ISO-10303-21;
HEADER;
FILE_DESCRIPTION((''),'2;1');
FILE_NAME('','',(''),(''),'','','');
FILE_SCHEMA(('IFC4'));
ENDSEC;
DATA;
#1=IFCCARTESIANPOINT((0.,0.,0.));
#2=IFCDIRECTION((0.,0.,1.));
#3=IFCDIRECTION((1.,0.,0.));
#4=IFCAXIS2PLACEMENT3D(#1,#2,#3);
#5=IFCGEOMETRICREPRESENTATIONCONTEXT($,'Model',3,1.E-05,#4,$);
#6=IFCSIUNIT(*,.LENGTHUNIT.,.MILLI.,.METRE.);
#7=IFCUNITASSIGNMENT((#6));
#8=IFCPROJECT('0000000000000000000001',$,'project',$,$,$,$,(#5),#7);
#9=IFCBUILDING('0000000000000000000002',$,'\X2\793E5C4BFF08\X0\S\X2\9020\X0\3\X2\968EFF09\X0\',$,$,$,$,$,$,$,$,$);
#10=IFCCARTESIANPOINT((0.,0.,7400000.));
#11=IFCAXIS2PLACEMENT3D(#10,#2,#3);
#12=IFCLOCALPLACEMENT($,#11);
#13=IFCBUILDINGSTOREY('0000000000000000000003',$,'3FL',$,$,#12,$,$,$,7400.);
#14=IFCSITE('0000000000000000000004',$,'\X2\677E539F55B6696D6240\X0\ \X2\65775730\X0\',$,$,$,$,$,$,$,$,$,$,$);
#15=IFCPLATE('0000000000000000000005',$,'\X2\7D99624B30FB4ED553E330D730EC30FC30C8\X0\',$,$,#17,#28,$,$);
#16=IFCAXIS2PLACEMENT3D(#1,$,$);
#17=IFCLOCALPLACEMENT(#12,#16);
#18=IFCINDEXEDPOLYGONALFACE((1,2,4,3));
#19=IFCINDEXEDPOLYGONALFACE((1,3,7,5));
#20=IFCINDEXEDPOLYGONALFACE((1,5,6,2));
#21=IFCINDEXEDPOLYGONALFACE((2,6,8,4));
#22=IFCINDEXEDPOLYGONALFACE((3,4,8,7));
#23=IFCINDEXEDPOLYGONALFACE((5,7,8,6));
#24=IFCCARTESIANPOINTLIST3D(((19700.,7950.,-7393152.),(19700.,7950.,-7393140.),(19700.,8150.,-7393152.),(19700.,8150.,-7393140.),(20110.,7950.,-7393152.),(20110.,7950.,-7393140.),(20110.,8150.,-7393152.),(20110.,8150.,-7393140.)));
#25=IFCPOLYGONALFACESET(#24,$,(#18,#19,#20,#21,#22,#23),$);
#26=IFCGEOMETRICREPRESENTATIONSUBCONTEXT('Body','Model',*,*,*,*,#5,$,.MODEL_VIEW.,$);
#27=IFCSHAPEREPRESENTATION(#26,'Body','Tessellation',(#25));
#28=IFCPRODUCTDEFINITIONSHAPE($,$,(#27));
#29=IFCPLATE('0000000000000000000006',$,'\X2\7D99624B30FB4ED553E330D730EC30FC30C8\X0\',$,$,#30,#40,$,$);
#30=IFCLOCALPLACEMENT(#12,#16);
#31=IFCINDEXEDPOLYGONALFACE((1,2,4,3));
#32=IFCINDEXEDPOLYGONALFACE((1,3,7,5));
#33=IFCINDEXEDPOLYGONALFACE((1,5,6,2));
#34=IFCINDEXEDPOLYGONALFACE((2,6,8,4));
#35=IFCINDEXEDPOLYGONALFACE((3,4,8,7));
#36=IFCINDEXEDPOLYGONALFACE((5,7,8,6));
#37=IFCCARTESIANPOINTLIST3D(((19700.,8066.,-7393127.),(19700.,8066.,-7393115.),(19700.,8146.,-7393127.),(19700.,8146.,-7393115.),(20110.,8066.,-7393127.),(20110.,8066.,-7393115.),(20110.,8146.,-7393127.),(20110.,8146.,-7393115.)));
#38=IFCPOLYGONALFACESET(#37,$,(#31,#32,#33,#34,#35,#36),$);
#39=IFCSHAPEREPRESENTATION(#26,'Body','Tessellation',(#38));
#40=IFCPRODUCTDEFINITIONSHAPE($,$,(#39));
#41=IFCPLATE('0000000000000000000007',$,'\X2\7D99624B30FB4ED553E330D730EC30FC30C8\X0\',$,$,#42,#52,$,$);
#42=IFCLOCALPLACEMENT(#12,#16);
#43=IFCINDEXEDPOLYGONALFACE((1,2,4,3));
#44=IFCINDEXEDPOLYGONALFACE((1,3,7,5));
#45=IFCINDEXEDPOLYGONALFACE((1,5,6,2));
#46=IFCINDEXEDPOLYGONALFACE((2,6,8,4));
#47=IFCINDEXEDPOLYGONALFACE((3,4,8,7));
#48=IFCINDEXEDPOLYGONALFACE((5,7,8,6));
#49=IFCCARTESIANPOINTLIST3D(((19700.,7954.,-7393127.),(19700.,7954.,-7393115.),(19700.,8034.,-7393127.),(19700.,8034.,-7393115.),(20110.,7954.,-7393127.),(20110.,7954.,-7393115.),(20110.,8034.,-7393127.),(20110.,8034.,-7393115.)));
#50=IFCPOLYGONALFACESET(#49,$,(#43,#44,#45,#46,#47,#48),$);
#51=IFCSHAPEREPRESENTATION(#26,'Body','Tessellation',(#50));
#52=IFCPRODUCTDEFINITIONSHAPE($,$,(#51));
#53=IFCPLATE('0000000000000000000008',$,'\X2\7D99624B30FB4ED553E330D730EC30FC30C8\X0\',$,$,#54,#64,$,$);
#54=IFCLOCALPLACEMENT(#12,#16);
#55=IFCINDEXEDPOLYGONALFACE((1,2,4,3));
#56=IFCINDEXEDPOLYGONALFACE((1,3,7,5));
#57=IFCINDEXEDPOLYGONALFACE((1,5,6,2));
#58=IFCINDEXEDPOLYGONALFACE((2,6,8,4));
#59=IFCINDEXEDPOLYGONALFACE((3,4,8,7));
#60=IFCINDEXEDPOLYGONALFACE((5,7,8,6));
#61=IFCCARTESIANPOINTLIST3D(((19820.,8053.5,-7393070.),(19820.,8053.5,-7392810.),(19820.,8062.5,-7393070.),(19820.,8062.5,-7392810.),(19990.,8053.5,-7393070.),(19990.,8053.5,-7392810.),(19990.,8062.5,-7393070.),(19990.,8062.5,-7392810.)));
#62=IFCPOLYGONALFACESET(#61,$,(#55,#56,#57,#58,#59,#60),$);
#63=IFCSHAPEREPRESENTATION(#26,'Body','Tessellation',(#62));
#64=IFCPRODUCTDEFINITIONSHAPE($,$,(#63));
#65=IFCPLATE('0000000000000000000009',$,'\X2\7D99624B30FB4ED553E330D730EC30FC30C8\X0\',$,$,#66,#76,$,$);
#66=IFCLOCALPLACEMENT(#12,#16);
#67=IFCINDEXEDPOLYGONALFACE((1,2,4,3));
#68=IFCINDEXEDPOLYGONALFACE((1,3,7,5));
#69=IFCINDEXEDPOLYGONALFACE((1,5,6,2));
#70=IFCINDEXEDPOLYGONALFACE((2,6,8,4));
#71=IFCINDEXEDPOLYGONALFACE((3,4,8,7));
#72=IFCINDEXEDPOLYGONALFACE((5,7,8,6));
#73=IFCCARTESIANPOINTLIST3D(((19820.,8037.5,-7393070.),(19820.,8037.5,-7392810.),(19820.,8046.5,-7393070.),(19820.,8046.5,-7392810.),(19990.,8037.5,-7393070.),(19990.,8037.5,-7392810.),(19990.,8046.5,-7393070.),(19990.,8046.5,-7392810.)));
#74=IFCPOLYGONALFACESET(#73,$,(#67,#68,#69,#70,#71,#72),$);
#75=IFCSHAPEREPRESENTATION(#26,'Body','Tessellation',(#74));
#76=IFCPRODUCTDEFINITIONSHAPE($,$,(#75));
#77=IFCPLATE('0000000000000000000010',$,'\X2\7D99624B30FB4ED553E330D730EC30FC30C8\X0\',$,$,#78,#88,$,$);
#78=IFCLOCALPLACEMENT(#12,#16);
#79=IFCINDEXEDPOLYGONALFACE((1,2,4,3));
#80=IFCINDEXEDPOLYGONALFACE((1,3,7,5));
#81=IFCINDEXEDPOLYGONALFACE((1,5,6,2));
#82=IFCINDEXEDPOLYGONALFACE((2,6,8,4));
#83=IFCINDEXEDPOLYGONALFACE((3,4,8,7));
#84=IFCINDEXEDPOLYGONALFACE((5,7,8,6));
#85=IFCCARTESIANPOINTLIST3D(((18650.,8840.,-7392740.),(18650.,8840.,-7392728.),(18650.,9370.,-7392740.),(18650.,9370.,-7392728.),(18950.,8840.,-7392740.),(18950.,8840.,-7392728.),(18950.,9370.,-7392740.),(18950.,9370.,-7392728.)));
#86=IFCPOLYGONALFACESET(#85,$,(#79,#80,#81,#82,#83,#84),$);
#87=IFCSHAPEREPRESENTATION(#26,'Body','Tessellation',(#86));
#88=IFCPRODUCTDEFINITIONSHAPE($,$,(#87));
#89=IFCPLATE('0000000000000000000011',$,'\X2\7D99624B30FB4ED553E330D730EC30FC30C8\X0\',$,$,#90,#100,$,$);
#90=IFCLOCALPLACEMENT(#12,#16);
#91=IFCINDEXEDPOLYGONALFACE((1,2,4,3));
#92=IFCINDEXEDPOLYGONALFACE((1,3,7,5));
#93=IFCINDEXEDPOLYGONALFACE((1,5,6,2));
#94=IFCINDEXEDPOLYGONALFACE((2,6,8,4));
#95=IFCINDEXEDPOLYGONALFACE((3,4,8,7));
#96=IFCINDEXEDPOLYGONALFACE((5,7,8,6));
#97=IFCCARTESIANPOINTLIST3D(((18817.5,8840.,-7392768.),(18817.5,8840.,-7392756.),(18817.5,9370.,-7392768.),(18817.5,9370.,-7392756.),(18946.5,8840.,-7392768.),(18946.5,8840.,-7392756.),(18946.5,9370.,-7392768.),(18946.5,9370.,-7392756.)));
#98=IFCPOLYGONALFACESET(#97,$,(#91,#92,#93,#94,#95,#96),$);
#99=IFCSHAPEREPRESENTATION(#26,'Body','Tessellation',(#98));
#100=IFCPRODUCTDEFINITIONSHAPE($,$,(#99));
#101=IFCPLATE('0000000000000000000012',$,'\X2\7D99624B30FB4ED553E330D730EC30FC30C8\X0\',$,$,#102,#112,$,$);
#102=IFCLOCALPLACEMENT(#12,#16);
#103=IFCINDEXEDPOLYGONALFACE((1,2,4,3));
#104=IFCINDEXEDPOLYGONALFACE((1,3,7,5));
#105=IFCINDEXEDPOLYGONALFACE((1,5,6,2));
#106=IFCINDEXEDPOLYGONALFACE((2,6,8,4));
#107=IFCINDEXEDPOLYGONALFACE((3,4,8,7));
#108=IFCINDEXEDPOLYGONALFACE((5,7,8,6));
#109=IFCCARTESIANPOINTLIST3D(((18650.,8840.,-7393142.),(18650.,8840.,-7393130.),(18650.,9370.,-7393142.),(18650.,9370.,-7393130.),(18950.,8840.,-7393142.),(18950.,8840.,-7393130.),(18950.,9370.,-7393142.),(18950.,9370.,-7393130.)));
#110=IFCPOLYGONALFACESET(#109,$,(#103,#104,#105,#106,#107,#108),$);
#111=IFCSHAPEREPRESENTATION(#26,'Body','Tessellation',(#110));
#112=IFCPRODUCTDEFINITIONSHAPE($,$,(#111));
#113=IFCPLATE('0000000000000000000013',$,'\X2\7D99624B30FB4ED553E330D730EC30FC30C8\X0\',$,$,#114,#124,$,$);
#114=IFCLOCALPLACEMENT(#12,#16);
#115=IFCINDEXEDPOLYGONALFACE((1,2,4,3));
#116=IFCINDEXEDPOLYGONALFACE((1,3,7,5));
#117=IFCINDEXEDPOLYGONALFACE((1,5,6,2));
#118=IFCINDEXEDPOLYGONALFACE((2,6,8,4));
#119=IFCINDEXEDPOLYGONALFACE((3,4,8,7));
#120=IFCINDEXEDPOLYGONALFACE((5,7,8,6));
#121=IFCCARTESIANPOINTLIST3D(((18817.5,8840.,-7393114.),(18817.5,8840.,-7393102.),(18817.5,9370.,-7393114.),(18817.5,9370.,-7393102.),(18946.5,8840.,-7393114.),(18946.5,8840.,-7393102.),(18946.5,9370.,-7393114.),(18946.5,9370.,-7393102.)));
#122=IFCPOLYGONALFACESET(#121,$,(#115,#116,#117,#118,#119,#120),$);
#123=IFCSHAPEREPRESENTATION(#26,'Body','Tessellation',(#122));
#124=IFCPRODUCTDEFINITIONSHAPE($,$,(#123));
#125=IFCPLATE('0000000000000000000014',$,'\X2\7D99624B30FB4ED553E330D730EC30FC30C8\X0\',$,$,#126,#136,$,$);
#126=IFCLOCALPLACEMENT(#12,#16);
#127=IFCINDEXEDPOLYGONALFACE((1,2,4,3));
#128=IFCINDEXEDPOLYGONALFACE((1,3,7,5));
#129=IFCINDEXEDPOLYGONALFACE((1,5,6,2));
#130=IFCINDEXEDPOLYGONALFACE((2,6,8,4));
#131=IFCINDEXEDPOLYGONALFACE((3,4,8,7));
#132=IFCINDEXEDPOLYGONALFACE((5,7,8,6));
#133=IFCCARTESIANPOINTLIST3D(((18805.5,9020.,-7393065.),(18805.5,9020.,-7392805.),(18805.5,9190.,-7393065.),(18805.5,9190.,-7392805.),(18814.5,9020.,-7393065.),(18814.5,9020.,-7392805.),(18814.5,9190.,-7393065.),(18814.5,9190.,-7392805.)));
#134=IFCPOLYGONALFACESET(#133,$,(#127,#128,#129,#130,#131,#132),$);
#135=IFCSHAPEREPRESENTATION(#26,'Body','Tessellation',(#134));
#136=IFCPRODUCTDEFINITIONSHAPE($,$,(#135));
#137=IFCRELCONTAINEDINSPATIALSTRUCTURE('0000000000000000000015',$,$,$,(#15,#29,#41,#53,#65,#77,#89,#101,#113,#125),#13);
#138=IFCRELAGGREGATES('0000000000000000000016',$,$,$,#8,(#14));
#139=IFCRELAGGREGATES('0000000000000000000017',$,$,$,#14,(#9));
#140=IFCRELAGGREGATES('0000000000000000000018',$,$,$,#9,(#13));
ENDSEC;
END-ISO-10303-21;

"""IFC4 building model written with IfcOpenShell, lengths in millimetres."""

from ifc_helpers import new_model, si_unit, frame, origin, origin_with_axes, place, context, subcontext, project, spatial, rectangle, extrude, element, save


model = new_model("IFC4")

# Units and contexts
model_context = context("Model", 3, precision=1e-05, world=origin_with_axes())
body_context = subcontext(model_context, "Body", "Model", "MODEL_VIEW")
ifc_project = project(units=[si_unit("LENGTHUNIT", "METRE", prefix="MILLI")], contexts=[model_context])

# Site, building, storey
site = spatial("IfcSite", under=ifc_project, Name="松原営業所 敷地")
building = spatial("IfcBuilding", under=site, Name="社屋（S造3階）")
storey_placement = place(None, frame((0.0, 0.0, 7400000.0), z_axis=(0.0, 0.0, 1.0), x_axis=(1.0, 0.0, 0.0)))
storey = spatial("IfcBuildingStorey", under=building, at=storey_placement, Name="3FL", Elevation=7400.0)

# Plates
plate_1_placement = place(storey_placement, frame((19700.0, 8050.0, -7393146.0), z_axis=(1.0, 0.0, 0.0), x_axis=(0.0, 1.0, 0.0)))
element("IfcPlate", 1, at=plate_1_placement, inside=storey, Name="継手・仕口プレート", context=body_context, shape_type="SweptSolid", body=[
    extrude(rectangle(XDim=200.0, YDim=12.0), origin(), (0.0, 0.0, 1.0), 410.0),
])
for number, where, z_axis, x_axis, name in (
    (2, (19700.0, 8106.0, -7393121.0), (1.0, 0.0, 0.0), (0.0, 1.0, 0.0), "継手・仕口プレート"),
    (3, (19700.0, 7994.0, -7393121.0), (1.0, 0.0, 0.0), (0.0, 1.0, 0.0), "継手・仕口プレート"),
):
    element("IfcPlate", number, at=place(storey_placement, frame(where, z_axis=z_axis, x_axis=x_axis)), inside=storey, Name=name, context=body_context, shape_type="SweptSolid", body=[
        extrude(rectangle(XDim=80.0, YDim=12.0), origin(), (0.0, 0.0, 1.0), 410.0),
    ])
for number, where, z_axis, x_axis, name in (
    (4, (19820.0, 8058.0, -7392940.0), (1.0, 0.0, 0.0), (0.0, 1.0, 0.0), "継手・仕口プレート"),
    (5, (19820.0, 8042.0, -7392940.0), (1.0, 0.0, 0.0), (0.0, 1.0, 0.0), "継手・仕口プレート"),
):
    element("IfcPlate", number, at=place(storey_placement, frame(where, z_axis=z_axis, x_axis=x_axis)), inside=storey, Name=name, context=body_context, shape_type="SweptSolid", body=[
        extrude(rectangle(XDim=9.0, YDim=260.0), origin(), (0.0, 0.0, 1.0), 170.0),
    ])
plate_2_placement = place(storey_placement, frame((18800.0, 8840.0, -7392734.0), z_axis=(0.0, 1.0, 0.0), x_axis=(-1.0, 0.0, 0.0)))
element("IfcPlate", 6, at=plate_2_placement, inside=storey, Name="継手・仕口プレート", context=body_context, shape_type="SweptSolid", body=[
    extrude(rectangle(XDim=300.0, YDim=12.0), origin(), (0.0, 0.0, 1.0), 530.0),
])
plate_3_placement = place(storey_placement, frame((18882.0, 8840.0, -7392762.0), z_axis=(0.0, 1.0, 0.0), x_axis=(-1.0, 0.0, 0.0)))
element("IfcPlate", 7, at=plate_3_placement, inside=storey, Name="継手・仕口プレート", context=body_context, shape_type="SweptSolid", body=[
    extrude(rectangle(XDim=129.0, YDim=12.0), origin(), (0.0, 0.0, 1.0), 530.0),
])
plate_4_placement = place(storey_placement, frame((18800.0, 8840.0, -7393136.0), z_axis=(0.0, 1.0, 0.0), x_axis=(-1.0, 0.0, 0.0)))
element("IfcPlate", 8, at=plate_4_placement, inside=storey, Name="継手・仕口プレート", context=body_context, shape_type="SweptSolid", body=[
    extrude(rectangle(XDim=300.0, YDim=12.0), origin(), (0.0, 0.0, 1.0), 530.0),
])
plate_5_placement = place(storey_placement, frame((18882.0, 8840.0, -7393108.0), z_axis=(0.0, 1.0, 0.0), x_axis=(-1.0, 0.0, 0.0)))
element("IfcPlate", 9, at=plate_5_placement, inside=storey, Name="継手・仕口プレート", context=body_context, shape_type="SweptSolid", body=[
    extrude(rectangle(XDim=129.0, YDim=12.0), origin(), (0.0, 0.0, 1.0), 530.0),
])
plate_6_placement = place(storey_placement, frame((18810.0, 9020.0, -7392935.0), z_axis=(0.0, 1.0, 0.0), x_axis=(-1.0, 0.0, 0.0)))
element("IfcPlate", 10, at=plate_6_placement, inside=storey, Name="継手・仕口プレート", context=body_context, shape_type="SweptSolid", body=[
    extrude(rectangle(XDim=9.0, YDim=260.0), origin(), (0.0, 0.0, 1.0), 170.0),
])

save(model, "model.ifc")
